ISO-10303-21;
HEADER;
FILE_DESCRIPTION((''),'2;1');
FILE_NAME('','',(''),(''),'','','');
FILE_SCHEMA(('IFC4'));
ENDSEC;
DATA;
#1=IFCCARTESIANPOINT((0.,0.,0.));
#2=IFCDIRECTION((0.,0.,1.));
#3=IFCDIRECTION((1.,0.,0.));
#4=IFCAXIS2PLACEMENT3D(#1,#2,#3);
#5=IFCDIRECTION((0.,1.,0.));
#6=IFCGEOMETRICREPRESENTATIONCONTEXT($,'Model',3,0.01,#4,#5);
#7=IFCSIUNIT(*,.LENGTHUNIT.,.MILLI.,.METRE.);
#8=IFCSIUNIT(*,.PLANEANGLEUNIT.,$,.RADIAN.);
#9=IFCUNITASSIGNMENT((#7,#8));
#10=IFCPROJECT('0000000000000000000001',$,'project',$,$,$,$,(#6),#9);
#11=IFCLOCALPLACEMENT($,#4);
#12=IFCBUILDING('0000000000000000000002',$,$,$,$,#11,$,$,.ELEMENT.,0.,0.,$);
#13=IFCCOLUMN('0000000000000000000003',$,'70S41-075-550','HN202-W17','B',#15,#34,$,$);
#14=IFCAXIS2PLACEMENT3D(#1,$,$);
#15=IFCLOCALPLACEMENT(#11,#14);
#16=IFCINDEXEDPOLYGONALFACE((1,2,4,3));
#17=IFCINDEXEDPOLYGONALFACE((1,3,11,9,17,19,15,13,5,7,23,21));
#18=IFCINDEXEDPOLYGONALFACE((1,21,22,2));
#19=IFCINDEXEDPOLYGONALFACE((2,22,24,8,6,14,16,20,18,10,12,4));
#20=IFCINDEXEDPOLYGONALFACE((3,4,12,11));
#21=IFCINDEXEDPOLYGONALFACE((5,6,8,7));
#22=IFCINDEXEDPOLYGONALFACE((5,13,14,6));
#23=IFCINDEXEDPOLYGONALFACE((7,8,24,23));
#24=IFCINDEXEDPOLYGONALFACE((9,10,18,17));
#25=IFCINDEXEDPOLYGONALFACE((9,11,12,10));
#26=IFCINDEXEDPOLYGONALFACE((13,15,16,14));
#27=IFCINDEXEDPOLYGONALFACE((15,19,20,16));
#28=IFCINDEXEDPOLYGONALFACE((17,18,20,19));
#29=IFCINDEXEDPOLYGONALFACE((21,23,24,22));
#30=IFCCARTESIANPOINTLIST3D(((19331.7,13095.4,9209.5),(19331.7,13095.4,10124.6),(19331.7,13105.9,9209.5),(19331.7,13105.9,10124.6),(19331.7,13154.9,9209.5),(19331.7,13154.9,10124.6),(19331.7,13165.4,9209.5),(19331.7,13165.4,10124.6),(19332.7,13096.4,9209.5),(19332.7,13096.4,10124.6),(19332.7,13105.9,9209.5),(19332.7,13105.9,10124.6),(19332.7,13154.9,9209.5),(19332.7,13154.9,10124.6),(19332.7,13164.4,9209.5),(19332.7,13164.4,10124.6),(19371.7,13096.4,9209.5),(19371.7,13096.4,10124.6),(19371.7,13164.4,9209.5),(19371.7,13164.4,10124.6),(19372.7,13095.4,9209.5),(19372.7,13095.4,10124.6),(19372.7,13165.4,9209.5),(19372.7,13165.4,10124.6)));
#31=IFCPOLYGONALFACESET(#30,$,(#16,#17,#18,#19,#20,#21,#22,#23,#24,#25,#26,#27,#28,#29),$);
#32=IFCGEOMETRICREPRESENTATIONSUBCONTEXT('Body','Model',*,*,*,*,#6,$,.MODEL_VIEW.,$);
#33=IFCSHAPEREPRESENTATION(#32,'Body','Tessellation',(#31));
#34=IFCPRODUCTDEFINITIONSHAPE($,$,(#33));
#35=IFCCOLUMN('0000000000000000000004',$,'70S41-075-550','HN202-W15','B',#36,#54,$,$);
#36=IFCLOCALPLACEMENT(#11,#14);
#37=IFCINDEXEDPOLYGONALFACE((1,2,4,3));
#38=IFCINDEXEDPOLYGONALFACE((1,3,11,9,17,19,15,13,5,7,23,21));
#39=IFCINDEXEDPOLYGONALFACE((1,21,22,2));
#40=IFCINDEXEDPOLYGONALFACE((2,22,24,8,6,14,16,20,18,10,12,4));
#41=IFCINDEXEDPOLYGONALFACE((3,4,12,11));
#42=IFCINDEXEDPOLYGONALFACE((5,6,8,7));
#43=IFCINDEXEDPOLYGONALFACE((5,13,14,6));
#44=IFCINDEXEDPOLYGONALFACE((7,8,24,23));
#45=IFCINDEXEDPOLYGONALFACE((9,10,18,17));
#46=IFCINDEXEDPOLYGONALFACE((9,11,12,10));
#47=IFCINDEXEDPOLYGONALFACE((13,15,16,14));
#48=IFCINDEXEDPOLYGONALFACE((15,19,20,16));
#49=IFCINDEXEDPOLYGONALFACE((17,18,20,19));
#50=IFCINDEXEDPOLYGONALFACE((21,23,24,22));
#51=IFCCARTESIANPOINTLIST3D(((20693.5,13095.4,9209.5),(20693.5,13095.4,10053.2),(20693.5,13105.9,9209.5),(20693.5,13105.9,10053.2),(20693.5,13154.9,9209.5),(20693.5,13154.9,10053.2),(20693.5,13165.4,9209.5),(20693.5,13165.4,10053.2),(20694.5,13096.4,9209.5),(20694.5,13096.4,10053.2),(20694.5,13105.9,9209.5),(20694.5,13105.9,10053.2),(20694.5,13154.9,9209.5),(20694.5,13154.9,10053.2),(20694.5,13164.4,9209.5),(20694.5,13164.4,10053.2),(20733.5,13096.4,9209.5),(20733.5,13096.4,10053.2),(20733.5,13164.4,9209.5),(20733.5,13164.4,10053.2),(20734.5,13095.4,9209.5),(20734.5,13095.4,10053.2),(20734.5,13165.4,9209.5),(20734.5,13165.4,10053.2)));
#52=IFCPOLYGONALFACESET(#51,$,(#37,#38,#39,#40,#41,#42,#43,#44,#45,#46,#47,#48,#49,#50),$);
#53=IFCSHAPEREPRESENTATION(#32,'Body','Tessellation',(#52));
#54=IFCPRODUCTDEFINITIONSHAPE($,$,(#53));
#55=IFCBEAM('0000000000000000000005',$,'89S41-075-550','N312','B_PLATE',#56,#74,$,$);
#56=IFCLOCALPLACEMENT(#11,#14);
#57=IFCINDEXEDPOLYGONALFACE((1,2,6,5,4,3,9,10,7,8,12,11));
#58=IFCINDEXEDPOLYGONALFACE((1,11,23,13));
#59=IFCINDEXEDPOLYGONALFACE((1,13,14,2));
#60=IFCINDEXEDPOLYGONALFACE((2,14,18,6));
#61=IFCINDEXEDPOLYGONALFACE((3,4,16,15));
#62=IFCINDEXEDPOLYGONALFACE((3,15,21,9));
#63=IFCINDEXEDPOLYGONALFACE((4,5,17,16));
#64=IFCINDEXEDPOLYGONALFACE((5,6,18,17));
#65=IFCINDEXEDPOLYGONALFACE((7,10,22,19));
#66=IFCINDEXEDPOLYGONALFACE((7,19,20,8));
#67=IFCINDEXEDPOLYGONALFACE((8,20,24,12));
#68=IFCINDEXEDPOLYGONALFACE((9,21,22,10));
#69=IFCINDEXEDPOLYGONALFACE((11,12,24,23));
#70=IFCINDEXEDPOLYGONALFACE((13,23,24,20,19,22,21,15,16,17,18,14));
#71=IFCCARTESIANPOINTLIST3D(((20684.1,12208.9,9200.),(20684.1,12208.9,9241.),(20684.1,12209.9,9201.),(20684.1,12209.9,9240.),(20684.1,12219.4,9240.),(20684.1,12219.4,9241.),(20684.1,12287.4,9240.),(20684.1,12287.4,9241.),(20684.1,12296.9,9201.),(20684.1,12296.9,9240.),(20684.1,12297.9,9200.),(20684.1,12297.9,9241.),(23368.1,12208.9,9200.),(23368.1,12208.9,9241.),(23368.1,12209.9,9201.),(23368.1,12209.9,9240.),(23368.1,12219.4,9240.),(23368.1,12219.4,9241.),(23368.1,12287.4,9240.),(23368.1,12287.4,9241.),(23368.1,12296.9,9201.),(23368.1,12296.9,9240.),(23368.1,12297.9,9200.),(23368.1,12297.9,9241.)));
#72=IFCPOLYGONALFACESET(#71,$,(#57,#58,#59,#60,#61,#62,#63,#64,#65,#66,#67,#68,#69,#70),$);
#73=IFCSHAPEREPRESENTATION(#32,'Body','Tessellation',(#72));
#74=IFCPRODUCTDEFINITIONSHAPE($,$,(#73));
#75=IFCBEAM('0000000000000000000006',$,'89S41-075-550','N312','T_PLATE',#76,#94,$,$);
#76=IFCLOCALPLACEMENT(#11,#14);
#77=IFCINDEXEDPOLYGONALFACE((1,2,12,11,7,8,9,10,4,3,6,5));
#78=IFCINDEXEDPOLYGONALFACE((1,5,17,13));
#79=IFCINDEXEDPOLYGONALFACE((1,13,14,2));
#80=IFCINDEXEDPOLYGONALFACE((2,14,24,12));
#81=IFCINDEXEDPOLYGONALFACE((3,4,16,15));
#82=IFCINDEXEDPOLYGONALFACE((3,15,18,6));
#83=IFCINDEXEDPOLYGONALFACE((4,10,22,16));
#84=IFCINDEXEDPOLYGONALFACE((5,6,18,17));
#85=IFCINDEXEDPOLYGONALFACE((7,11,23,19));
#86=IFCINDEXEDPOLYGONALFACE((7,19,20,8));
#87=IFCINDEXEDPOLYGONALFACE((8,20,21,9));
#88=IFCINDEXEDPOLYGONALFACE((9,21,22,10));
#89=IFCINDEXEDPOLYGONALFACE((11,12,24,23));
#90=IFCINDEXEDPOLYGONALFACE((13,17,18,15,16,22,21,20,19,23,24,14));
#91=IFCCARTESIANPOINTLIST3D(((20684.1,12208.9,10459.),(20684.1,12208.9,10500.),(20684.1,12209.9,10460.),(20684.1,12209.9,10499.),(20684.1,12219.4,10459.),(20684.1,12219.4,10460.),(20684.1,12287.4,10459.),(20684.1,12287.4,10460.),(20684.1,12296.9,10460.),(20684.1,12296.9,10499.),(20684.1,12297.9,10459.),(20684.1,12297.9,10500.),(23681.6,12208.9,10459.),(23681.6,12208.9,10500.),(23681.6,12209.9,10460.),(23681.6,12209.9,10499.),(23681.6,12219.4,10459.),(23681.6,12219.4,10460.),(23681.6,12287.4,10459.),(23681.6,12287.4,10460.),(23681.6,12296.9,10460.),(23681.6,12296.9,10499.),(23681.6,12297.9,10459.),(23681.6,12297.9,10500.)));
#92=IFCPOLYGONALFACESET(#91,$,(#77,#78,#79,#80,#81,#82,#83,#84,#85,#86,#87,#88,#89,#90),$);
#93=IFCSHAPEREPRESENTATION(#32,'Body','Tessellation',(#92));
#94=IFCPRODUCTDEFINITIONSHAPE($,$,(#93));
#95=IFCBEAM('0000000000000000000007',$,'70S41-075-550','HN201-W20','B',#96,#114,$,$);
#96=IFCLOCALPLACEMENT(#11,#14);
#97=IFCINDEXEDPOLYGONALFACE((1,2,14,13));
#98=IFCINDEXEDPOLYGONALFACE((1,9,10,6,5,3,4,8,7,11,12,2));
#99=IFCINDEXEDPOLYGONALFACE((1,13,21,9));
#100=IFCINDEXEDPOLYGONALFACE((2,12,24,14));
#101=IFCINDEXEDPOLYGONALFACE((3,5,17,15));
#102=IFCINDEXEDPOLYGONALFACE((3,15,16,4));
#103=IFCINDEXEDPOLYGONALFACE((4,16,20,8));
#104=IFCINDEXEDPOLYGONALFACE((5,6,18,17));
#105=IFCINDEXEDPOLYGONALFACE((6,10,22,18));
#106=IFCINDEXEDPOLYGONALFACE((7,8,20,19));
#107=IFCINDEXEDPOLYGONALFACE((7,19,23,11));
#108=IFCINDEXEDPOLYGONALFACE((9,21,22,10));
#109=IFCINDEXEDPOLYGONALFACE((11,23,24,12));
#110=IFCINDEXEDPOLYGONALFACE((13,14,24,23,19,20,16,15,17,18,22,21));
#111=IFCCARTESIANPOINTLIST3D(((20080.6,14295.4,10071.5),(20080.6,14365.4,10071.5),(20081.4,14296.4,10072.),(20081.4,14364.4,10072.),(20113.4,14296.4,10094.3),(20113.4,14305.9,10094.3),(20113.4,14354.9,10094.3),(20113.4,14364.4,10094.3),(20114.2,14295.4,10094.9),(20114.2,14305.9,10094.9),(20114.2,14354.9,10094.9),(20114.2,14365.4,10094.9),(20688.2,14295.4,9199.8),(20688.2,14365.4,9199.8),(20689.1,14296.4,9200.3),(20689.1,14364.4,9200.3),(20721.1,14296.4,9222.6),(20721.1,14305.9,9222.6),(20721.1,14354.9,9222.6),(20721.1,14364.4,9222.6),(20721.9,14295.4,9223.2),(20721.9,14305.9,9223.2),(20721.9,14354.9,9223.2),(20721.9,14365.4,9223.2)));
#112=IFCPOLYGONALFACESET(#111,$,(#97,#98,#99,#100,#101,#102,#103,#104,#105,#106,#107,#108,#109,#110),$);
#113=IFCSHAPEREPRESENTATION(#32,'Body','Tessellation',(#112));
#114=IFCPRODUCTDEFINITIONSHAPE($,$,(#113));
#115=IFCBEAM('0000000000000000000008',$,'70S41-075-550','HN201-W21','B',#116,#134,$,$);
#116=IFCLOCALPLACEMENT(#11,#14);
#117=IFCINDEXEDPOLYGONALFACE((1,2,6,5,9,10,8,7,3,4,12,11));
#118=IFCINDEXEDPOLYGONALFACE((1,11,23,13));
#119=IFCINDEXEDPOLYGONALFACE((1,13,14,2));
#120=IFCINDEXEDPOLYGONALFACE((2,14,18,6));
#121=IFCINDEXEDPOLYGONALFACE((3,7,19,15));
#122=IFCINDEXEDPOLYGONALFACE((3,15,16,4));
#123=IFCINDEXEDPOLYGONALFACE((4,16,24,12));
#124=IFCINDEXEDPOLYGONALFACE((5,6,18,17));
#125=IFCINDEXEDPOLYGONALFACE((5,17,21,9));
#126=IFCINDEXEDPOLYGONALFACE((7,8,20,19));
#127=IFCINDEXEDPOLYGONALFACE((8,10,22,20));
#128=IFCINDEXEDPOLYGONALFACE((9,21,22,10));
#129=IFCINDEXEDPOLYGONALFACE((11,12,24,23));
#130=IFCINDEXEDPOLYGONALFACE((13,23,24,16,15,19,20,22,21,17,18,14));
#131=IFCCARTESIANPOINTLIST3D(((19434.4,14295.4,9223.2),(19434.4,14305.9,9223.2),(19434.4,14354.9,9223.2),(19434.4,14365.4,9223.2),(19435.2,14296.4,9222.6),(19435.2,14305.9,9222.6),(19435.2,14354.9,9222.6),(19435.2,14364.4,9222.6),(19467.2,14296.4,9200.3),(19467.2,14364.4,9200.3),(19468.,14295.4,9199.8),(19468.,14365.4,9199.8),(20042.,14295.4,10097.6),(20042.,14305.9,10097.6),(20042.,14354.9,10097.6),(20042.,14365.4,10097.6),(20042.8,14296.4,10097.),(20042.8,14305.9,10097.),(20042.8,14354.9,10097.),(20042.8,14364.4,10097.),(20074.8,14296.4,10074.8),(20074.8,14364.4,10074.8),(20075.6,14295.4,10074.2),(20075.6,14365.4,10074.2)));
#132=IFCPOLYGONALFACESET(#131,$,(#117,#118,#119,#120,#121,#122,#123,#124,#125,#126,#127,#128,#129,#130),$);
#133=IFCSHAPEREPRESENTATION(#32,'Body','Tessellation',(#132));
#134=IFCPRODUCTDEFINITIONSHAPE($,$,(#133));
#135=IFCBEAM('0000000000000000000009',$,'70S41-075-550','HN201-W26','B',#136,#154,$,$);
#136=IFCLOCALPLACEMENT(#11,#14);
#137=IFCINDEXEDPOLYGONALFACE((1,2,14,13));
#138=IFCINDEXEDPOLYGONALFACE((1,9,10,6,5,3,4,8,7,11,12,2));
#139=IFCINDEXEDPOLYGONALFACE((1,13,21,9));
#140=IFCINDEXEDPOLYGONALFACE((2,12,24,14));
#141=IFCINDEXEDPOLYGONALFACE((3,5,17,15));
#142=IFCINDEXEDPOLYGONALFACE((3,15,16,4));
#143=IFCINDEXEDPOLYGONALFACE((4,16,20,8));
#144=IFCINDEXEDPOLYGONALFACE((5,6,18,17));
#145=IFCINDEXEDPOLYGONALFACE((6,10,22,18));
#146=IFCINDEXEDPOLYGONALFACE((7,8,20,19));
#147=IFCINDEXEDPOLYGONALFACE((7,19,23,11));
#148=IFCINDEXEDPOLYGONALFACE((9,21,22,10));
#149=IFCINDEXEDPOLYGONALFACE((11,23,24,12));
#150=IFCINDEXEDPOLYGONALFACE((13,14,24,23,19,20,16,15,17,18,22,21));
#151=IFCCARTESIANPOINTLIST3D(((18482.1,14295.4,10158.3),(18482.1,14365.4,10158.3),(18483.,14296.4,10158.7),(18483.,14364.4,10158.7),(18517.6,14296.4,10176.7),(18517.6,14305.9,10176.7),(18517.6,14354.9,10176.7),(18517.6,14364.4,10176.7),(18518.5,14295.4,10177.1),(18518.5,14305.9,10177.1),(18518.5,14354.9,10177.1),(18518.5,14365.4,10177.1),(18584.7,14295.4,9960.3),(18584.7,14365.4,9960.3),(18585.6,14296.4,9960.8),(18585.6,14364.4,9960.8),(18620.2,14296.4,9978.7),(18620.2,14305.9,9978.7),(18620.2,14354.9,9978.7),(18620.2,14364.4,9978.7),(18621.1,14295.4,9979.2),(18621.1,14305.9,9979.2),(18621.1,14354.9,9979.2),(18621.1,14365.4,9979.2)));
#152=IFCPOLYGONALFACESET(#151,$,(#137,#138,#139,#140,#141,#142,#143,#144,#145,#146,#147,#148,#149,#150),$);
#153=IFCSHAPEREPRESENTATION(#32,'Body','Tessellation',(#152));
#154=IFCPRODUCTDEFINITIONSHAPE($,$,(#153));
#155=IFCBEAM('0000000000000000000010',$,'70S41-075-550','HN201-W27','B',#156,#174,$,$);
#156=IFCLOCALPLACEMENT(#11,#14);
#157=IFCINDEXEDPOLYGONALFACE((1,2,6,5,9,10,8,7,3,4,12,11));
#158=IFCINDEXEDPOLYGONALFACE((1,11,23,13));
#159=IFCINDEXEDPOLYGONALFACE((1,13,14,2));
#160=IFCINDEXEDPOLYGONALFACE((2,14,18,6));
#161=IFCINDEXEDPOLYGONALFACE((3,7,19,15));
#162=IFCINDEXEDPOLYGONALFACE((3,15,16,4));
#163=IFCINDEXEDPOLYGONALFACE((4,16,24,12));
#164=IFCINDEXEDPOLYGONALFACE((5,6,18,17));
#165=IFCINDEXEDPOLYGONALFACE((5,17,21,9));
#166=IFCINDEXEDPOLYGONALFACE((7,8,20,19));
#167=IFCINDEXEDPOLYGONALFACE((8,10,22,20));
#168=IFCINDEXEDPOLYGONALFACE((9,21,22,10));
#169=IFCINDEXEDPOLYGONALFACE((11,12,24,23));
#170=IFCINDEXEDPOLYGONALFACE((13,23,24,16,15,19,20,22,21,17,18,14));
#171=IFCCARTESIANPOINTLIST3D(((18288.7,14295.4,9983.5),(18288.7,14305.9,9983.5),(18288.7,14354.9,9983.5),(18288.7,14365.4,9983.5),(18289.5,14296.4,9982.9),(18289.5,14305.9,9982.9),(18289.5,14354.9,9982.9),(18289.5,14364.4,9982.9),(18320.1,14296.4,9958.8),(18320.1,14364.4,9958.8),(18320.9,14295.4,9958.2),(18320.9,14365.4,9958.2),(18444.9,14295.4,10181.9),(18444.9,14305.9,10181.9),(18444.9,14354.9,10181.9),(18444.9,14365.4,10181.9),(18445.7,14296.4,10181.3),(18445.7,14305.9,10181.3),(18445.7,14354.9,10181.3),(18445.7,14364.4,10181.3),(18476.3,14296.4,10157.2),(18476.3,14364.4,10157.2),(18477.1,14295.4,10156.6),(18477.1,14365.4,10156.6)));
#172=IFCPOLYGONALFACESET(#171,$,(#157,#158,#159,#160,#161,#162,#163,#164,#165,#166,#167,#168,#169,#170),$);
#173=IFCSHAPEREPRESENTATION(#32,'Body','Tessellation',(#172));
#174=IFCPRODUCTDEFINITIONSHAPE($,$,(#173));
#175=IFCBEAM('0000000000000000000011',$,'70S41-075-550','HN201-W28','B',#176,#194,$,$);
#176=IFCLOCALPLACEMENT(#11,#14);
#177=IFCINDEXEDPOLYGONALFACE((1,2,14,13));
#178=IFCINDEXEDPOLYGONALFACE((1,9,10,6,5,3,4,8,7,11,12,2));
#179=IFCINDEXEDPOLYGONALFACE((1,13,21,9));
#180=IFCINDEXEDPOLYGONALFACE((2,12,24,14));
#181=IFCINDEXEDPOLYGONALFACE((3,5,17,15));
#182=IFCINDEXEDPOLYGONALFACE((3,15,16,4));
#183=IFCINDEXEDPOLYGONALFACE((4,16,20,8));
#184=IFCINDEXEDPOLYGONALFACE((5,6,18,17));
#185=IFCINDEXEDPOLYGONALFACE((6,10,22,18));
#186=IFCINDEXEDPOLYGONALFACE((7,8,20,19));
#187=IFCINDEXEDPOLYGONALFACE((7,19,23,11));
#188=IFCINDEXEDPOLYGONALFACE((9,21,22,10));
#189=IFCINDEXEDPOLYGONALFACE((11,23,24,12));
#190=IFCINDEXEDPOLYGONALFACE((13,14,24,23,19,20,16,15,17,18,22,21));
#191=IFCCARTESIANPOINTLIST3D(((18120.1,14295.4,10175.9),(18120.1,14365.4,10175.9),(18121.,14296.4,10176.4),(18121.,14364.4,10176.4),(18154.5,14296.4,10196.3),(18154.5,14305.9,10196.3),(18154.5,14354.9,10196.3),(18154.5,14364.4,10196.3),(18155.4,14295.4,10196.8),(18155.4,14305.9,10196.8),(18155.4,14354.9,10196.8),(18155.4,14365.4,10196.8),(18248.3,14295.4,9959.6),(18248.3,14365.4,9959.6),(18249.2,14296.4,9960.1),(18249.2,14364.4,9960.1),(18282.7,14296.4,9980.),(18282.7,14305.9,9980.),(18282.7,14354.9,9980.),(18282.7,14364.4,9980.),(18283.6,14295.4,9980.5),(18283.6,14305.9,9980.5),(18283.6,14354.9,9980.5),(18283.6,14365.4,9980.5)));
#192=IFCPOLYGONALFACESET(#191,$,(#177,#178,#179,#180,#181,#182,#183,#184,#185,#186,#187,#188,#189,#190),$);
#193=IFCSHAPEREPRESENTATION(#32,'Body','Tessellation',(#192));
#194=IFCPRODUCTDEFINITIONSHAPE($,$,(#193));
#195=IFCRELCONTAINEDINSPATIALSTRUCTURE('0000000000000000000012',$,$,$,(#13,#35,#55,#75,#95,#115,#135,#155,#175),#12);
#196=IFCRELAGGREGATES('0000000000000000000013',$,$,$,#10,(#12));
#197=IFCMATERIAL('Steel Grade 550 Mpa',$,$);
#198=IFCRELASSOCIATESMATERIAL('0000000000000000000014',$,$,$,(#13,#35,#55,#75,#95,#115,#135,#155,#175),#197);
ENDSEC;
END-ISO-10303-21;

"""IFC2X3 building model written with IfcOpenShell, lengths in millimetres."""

from ifc_helpers import new_model, si_unit, direction, frame, origin, origin_with_axes, origin_2d_with_axis, place, context, subcontext, project, spatial, c_section, extrude, source, transform, mapped, material, element, save


model = new_model("IFC2X3")

# Units and contexts
model_context = context("Model", 3, precision=0.01, world=origin_with_axes(), true_north=direction((0.0, 1.0, 0.0)))
body_context = subcontext(model_context, "Body", "Model", "MODEL_VIEW")
ifc_project = project(units=[si_unit("LENGTHUNIT", "METRE", prefix="MILLI"), si_unit("PLANEANGLEUNIT", "RADIAN")], contexts=[model_context])

# Building
building_placement = place(None, origin_with_axes())
building = spatial("IfcBuilding", under=ifc_project, at=building_placement, CompositionType="ELEMENT", ElevationOfRefHeight=0.0, ElevationOfTerrain=0.0)

# Columns
ifc_material = material(Name="Steel Grade 550 Mpa")
shared_shape_1 = source(origin(), body_context, "Body", "SweptSolid", [
    extrude(c_section(Depth=70.0, Width=41.0, WallThickness=1.0, Girth=10.5, at=origin_2d_with_axis()), origin_with_axes(), (0.0, 0.0, 1.0), 915.1),
])
column_1_placement = place(None, frame((19352.2, 13130.4, 10124.6), z_axis=(0.0, 0.0, -1.0), x_axis=(-1.0, 0.0, 0.0)))
element("IfcColumn", 1, at=column_1_placement, inside=building, material=ifc_material, Name="70S41-075-550", Description="HN202-W17", ObjectType="B", context=body_context, shape_type="MappedRepresentation", body=[
    mapped(shared_shape_1, transform((0.0, 0.0, 0.0), scale=1.0)),
])
shared_shape_2 = source(origin(), body_context, "Body", "SweptSolid", [
    extrude(c_section(Depth=70.0, Width=41.0, WallThickness=1.0, Girth=10.5, at=origin_2d_with_axis()), origin_with_axes(), (0.0, 0.0, 1.0), 843.7),
])
column_2_placement = place(None, frame((20714.0, 13130.4, 10053.2), z_axis=(0.0, 0.0, -1.0), x_axis=(-1.0, 0.0, 0.0)))
element("IfcColumn", 2, at=column_2_placement, inside=building, material=ifc_material, Name="70S41-075-550", Description="HN202-W15", ObjectType="B", context=body_context, shape_type="MappedRepresentation", body=[
    mapped(shared_shape_2, transform((0.0, 0.0, 0.0), scale=1.0)),
])

# Beams
shared_shape_3 = source(origin(), body_context, "Body", "SweptSolid", [
    extrude(c_section(Depth=89.0, Width=41.0, WallThickness=1.0, Girth=10.5, at=origin_2d_with_axis()), origin_with_axes(), (0.0, 0.0, 1.0), 2684.0),
])
beam_1_placement = place(None, frame((20684.1, 12253.4, 9220.5), z_axis=(1.0, 0.0, 0.0), x_axis=(0.0, 0.0, 1.0)))
element("IfcBeam", 3, at=beam_1_placement, inside=building, material=ifc_material, Name="89S41-075-550", Description="N312", ObjectType="B_PLATE", context=body_context, shape_type="MappedRepresentation", body=[
    mapped(shared_shape_3, transform((0.0, 0.0, 0.0), scale=1.0)),
])
shared_shape_4 = source(origin(), body_context, "Body", "SweptSolid", [
    extrude(c_section(Depth=89.0, Width=41.0, WallThickness=1.0, Girth=10.5, at=origin_2d_with_axis()), origin_with_axes(), (0.0, 0.0, 1.0), 2997.5),
])
beam_2_placement = place(None, frame((20684.1, 12253.4, 10479.5), z_axis=(1.0, 0.0, 0.0), x_axis=(0.0, 0.0, -1.0)))
element("IfcBeam", 4, at=beam_2_placement, inside=building, material=ifc_material, Name="89S41-075-550", Description="N312", ObjectType="T_PLATE", context=body_context, shape_type="MappedRepresentation", body=[
    mapped(shared_shape_4, transform((0.0, 0.0, 0.0), scale=1.0)),
])
shared_shape_5 = source(origin(), body_context, "Body", "SweptSolid", [
    extrude(c_section(Depth=70.0, Width=41.0, WallThickness=1.0, Girth=10.5, at=origin_2d_with_axis()), origin_with_axes(), (0.0, 0.0, 1.0), 1062.6),
])
beam_3_placement = place(None, frame((20705.1, 14330.4, 9211.5), z_axis=(-0.571844, 0.0, 0.820363), x_axis=(0.820363, 0.0, 0.571844)))
element("IfcBeam", 5, at=beam_3_placement, inside=building, material=ifc_material, Name="70S41-075-550", Description="HN201-W20", ObjectType="B", context=body_context, shape_type="MappedRepresentation", body=[
    mapped(shared_shape_5, transform((0.0, 0.0, 0.0), scale=1.0)),
])
shared_shape_6 = source(origin(), body_context, "Body", "SweptSolid", [
    extrude(c_section(Depth=70.0, Width=41.0, WallThickness=1.0, Girth=10.5, at=origin_2d_with_axis()), origin_with_axes(), (0.0, 0.0, 1.0), 1064.8),
])
beam_4_placement = place(None, frame((20058.8, 14330.4, 10085.9), z_axis=(-0.570636, 0.0, -0.821203), x_axis=(-0.821203, 0.0, 0.570636)))
element("IfcBeam", 6, at=beam_4_placement, inside=building, material=ifc_material, Name="70S41-075-550", Description="HN201-W21", ObjectType="B", context=body_context, shape_type="MappedRepresentation", body=[
    mapped(shared_shape_6, transform((0.0, 0.0, 0.0), scale=1.0)),
])
shared_shape_7 = source(origin(), body_context, "Body", "SweptSolid", [
    extrude(c_section(Depth=70.0, Width=41.0, WallThickness=1.0, Girth=10.5, at=origin_2d_with_axis()), origin_with_axes(), (0.0, 0.0, 1.0), 223.0),
])
beam_5_placement = place(None, frame((18602.9, 14330.4, 9969.7), z_axis=(-0.460146, 0.0, 0.887843), x_axis=(0.887843, 0.0, 0.460146)))
element("IfcBeam", 7, at=beam_5_placement, inside=building, material=ifc_material, Name="70S41-075-550", Description="HN201-W26", ObjectType="B", context=body_context, shape_type="MappedRepresentation", body=[
    mapped(shared_shape_7, transform((0.0, 0.0, 0.0), scale=1.0)),
])
shared_shape_8 = source(origin(), body_context, "Body", "SweptSolid", [
    extrude(c_section(Depth=70.0, Width=41.0, WallThickness=1.0, Girth=10.5, at=origin_2d_with_axis()), origin_with_axes(), (0.0, 0.0, 1.0), 252.5),
])
beam_6_placement = place(None, frame((18461.0, 14330.4, 10169.3), z_axis=(-0.618616, 0.0, -0.785693), x_axis=(-0.785693, 0.0, 0.618616)))
element("IfcBeam", 8, at=beam_6_placement, inside=building, material=ifc_material, Name="70S41-075-550", Description="HN201-W27", ObjectType="B", context=body_context, shape_type="MappedRepresentation", body=[
    mapped(shared_shape_8, transform((0.0, 0.0, 0.0), scale=1.0)),
])
shared_shape_9 = source(origin(), body_context, "Body", "SweptSolid", [
    extrude(c_section(Depth=70.0, Width=41.0, WallThickness=1.0, Girth=10.5, at=origin_2d_with_axis()), origin_with_axes(), (0.0, 0.0, 1.0), 251.5),
])
beam_7_placement = place(None, frame((18266.0, 14330.4, 9970.0), z_axis=(-0.509898, 0.0, 0.860235), x_axis=(0.860235, 0.0, 0.509898)))
element("IfcBeam", 9, at=beam_7_placement, inside=building, material=ifc_material, Name="70S41-075-550", Description="HN201-W28", ObjectType="B", context=body_context, shape_type="MappedRepresentation", body=[
    mapped(shared_shape_9, transform((0.0, 0.0, 0.0), scale=1.0)),
])

save(model, "model.ifc")
